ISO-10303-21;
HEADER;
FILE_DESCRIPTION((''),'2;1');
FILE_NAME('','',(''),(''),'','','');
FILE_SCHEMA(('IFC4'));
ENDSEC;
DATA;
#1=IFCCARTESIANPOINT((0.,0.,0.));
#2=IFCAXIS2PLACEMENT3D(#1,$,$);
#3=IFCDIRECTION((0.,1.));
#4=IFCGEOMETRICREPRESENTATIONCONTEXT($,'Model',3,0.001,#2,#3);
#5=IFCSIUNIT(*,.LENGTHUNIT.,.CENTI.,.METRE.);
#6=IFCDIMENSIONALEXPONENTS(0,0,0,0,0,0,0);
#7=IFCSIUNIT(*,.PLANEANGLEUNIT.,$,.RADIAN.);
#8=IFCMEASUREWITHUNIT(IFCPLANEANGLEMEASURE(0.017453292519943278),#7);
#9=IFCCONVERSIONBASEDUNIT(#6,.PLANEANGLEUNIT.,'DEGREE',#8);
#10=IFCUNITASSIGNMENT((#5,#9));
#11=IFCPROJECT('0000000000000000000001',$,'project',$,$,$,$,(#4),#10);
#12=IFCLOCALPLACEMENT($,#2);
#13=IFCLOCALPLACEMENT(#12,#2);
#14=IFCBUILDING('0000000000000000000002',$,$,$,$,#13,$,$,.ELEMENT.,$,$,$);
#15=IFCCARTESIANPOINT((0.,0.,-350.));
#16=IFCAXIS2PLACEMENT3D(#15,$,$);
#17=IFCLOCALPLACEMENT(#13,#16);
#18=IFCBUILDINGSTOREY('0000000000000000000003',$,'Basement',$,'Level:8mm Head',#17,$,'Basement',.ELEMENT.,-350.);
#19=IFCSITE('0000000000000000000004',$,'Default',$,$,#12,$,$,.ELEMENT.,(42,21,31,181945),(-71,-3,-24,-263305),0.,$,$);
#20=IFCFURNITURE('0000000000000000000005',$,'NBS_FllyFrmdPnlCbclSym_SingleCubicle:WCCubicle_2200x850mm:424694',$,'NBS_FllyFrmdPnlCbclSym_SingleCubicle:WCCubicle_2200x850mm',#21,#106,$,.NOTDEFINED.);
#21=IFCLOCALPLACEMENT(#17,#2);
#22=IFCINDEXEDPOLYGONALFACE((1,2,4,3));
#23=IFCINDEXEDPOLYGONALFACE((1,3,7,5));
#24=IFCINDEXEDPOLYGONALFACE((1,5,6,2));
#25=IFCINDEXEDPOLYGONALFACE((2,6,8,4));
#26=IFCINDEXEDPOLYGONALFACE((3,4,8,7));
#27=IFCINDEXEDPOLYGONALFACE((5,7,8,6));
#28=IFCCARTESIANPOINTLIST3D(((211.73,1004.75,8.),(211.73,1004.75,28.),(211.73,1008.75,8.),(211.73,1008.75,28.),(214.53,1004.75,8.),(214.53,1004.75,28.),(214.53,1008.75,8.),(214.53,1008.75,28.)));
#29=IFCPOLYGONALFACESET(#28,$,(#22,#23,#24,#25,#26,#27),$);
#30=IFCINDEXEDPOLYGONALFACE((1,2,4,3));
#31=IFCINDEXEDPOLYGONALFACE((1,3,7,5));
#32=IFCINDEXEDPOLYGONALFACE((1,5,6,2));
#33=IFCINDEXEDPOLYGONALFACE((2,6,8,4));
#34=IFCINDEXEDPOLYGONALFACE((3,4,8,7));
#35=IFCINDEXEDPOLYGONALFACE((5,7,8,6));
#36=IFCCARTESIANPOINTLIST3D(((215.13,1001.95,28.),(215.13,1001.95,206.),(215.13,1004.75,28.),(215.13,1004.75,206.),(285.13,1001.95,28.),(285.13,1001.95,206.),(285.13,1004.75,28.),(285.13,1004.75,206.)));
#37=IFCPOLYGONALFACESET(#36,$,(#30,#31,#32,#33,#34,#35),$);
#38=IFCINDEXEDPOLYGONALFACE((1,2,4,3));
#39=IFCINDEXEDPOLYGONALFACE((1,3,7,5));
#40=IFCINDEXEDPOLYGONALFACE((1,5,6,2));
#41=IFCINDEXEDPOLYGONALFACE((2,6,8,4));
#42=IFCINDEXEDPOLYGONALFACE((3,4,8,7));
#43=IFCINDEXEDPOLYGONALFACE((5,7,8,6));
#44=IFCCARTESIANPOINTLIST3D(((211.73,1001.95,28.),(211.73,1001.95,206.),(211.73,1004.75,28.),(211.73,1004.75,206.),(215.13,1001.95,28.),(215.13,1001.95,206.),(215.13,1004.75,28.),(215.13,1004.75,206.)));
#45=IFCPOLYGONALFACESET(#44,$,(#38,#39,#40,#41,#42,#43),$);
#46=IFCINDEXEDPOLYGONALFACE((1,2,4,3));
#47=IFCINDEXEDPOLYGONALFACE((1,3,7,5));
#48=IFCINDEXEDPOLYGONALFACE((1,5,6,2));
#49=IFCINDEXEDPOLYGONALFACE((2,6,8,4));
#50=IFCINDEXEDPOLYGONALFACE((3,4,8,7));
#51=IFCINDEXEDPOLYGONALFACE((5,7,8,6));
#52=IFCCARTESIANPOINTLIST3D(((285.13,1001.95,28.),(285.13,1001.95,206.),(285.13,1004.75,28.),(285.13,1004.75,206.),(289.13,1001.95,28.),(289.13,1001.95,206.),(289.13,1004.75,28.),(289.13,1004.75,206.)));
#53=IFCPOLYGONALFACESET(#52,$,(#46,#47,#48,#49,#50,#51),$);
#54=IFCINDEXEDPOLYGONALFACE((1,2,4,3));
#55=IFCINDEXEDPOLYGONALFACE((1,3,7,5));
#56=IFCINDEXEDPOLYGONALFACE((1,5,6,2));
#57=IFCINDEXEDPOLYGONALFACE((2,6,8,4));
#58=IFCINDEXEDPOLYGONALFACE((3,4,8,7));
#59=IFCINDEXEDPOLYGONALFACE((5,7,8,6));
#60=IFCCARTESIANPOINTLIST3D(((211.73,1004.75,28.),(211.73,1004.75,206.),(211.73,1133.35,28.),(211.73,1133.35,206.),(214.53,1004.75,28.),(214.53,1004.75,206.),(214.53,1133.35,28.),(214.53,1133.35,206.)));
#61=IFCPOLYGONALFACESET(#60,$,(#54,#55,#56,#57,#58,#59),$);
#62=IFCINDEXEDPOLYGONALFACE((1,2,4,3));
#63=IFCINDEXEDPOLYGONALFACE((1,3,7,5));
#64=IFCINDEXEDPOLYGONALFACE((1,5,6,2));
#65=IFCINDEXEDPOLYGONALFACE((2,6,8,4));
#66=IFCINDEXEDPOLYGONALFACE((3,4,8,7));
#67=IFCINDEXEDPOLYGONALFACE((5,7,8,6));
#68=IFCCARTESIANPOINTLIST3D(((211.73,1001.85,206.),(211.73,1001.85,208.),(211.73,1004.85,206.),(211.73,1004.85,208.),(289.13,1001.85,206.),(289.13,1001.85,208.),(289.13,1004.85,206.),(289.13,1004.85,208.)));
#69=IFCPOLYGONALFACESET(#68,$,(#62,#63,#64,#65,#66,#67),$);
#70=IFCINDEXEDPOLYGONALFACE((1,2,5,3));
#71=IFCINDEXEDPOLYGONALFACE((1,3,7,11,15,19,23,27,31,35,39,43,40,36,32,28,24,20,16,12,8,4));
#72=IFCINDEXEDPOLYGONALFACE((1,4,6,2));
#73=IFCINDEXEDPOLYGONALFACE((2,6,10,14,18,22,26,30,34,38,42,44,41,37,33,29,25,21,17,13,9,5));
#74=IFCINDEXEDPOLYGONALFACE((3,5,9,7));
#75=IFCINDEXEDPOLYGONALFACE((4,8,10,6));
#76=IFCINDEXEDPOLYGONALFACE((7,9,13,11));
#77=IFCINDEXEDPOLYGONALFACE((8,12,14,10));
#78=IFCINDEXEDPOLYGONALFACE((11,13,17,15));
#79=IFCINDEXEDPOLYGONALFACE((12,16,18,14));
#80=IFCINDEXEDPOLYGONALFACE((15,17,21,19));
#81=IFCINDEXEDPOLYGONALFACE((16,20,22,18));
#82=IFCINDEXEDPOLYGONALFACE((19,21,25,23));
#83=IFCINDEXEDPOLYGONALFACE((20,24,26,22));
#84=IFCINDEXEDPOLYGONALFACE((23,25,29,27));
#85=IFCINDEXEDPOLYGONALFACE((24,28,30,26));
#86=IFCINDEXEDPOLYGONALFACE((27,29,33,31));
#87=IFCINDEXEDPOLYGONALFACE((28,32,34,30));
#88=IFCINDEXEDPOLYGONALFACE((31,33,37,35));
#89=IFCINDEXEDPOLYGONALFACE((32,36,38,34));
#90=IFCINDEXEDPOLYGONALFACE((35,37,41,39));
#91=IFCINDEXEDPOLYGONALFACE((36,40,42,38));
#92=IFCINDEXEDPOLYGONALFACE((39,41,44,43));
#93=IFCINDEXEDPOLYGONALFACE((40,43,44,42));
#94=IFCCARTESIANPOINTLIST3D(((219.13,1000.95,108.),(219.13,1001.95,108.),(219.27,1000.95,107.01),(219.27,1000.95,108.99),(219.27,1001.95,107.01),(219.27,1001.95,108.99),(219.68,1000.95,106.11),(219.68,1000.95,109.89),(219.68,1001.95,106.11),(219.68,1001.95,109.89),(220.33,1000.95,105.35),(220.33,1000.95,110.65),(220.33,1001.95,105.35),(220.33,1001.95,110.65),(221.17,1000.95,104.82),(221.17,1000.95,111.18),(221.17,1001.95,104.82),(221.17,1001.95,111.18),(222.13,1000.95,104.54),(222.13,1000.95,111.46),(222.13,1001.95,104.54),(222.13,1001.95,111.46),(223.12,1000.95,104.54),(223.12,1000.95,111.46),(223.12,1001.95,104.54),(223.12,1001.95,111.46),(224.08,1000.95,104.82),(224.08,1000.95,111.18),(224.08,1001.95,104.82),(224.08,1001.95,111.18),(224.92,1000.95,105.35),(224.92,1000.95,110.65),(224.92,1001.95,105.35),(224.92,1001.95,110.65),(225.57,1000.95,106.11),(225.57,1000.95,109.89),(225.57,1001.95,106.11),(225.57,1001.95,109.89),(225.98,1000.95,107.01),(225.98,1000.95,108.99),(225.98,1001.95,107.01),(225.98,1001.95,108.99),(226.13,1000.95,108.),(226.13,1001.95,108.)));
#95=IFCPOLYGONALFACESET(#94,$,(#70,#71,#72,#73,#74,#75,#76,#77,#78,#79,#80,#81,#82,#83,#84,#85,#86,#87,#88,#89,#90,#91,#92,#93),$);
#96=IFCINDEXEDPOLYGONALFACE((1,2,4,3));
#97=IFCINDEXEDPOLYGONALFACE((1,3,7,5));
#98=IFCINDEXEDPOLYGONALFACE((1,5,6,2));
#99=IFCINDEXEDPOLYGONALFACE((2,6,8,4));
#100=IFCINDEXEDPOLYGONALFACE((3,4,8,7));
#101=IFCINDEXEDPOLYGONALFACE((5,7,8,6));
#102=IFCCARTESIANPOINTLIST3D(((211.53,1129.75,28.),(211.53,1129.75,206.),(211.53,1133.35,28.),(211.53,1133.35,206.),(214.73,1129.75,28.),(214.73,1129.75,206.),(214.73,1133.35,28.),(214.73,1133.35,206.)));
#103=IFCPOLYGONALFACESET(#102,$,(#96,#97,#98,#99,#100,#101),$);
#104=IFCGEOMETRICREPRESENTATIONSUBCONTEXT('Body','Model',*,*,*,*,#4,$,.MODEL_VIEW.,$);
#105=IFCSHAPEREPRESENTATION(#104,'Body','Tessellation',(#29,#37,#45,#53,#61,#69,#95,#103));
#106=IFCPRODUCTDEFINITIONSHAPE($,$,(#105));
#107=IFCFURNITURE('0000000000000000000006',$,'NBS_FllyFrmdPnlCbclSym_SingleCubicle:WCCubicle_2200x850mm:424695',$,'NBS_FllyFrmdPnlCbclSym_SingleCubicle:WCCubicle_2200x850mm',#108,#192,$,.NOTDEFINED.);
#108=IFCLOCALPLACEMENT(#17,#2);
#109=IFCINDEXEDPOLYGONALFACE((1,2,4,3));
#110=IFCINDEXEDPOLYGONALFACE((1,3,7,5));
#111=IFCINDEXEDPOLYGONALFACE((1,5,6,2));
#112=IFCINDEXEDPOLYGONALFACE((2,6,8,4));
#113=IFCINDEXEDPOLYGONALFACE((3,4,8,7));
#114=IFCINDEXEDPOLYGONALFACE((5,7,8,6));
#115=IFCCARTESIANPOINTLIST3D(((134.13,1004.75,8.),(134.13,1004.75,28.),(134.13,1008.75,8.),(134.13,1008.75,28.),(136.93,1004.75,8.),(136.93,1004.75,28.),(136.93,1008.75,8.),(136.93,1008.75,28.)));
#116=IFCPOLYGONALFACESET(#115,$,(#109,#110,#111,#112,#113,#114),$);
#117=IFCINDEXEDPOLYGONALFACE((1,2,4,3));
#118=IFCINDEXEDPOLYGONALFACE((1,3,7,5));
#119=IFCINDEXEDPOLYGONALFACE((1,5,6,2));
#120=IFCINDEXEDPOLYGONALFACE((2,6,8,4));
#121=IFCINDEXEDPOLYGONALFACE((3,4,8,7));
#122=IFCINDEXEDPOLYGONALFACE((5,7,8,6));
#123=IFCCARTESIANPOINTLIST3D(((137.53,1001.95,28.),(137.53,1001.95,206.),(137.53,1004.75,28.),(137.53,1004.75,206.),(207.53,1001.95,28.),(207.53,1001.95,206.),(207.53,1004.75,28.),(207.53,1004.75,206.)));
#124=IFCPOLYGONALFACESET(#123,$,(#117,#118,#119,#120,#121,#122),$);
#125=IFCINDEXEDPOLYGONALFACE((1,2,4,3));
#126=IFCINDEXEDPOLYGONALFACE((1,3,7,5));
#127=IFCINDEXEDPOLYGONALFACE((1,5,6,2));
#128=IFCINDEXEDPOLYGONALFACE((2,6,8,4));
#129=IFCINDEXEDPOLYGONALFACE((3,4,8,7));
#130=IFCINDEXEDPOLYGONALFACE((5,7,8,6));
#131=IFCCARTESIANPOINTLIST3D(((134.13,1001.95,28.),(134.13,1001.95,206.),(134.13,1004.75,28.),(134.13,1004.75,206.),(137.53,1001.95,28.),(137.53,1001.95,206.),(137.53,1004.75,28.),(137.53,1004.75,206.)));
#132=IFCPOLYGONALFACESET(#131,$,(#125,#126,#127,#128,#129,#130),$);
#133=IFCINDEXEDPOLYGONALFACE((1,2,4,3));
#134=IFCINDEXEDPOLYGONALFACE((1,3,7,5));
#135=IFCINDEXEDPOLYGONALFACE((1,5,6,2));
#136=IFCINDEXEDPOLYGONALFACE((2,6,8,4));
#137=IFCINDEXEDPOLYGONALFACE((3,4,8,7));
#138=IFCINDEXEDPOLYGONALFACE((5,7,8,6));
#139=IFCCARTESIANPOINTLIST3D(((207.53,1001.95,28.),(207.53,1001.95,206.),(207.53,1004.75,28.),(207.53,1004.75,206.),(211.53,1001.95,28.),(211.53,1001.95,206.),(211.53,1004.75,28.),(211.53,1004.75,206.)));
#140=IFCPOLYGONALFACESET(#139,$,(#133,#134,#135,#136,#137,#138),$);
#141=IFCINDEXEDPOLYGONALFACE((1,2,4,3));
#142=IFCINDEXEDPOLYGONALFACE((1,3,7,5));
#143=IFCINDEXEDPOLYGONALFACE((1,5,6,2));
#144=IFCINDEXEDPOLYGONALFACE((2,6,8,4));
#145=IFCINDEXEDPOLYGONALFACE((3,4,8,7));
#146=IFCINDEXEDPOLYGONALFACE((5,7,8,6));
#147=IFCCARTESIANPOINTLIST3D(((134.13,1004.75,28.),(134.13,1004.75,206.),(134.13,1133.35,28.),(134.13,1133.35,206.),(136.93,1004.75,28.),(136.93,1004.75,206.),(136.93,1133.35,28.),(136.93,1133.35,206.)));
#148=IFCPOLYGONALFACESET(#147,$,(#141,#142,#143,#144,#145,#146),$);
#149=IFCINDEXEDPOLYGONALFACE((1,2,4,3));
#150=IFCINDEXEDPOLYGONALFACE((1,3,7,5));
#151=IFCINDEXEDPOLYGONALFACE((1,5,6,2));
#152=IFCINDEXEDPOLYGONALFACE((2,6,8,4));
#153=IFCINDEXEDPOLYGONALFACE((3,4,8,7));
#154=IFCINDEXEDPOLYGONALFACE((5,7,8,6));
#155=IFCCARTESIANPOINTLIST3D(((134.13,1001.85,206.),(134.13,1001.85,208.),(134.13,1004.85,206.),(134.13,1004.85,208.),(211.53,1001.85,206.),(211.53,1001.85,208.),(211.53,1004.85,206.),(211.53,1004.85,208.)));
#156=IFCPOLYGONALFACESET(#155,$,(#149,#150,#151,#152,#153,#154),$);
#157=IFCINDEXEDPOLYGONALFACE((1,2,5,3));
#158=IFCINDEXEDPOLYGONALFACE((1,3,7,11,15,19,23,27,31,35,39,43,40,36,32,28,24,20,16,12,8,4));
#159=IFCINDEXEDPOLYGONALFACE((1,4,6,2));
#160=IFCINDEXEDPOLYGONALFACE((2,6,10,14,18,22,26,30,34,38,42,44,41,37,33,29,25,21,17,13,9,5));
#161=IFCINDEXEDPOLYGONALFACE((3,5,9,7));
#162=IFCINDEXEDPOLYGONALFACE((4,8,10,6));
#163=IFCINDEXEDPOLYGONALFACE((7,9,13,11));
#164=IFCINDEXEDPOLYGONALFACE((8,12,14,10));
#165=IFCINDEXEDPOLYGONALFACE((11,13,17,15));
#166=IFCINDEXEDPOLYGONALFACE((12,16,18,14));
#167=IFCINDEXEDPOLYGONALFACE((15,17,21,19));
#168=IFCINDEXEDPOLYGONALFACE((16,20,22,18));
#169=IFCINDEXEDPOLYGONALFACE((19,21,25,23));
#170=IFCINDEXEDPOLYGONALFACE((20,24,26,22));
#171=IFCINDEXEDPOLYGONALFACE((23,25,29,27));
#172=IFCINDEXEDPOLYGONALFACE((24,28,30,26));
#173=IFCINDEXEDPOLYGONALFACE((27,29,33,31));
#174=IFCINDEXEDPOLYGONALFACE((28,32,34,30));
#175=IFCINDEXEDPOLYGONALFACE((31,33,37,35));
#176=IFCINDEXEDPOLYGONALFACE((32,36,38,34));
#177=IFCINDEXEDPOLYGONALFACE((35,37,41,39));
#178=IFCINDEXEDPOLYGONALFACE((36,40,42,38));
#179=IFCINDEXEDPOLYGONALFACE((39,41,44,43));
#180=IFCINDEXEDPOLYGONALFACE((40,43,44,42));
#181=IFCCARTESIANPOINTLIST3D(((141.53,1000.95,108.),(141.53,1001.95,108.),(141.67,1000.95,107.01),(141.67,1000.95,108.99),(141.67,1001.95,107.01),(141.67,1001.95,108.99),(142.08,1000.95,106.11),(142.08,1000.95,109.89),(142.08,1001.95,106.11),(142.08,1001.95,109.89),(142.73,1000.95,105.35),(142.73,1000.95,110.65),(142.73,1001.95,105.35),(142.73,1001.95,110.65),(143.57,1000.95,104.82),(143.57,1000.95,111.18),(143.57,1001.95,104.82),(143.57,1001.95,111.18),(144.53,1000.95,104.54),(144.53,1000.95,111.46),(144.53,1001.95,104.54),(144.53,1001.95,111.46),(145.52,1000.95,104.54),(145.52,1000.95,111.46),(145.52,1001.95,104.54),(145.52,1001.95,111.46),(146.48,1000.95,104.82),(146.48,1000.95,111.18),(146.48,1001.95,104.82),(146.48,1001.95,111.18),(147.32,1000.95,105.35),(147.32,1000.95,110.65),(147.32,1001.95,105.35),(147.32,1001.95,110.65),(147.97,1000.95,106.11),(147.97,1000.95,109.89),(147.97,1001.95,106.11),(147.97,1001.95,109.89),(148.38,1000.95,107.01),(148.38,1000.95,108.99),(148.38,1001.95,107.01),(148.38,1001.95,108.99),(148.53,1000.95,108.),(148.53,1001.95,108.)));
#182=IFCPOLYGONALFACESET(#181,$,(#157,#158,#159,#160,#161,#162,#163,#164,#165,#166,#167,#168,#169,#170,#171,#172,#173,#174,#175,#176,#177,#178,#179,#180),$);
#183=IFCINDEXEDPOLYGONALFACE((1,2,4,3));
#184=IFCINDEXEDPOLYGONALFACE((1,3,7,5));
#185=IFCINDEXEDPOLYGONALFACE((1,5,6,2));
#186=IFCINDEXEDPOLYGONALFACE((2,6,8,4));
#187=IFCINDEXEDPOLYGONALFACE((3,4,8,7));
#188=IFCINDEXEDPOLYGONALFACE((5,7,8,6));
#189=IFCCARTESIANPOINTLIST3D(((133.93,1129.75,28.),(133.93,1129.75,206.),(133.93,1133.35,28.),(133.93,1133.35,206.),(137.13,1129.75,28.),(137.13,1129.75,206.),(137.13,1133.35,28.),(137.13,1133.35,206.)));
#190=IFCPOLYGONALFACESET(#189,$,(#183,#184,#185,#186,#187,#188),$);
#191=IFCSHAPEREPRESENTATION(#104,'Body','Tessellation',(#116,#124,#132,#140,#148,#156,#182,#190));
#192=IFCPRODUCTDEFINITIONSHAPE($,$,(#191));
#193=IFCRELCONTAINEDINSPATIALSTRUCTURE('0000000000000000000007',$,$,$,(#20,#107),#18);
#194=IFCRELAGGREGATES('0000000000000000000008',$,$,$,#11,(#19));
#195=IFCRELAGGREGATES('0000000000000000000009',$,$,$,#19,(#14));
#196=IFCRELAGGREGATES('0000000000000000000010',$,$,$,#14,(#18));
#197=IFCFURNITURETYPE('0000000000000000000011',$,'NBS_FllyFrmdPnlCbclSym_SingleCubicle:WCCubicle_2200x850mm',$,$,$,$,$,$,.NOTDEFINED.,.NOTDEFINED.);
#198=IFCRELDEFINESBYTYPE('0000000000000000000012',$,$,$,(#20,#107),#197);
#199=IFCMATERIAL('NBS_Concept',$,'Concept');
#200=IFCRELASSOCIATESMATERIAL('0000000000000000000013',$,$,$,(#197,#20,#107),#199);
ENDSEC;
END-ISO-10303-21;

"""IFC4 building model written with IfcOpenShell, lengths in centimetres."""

from ifc_helpers import new_model, entity, si_unit, converted_unit, direction, frame, origin, place, context, subcontext, project, spatial, arc, indexed_curve, outline, extrude, source, transform, mapped, material, type_object, type_shapes, element, save


model = new_model("IFC4")

# Units and contexts
model_context = context("Model", 3, precision=0.001, world=origin(), true_north=direction((0.0, 1.0)))
body_context = subcontext(model_context, "Body", "Model", "MODEL_VIEW")
ifc_project = project(units=[si_unit("LENGTHUNIT", "METRE", prefix="CENTI"), converted_unit("PLANEANGLEUNIT", "DEGREE", entity("IfcPlaneAngleMeasure", 0.017453292519943278), si_unit("PLANEANGLEUNIT", "RADIAN"), dimensions=[0, 0, 0, 0, 0, 0, 0])], contexts=[model_context])

# Site, building, storey
site_placement = place(None, origin())
site = spatial("IfcSite", under=ifc_project, at=site_placement, Name="Default", CompositionType="ELEMENT", RefLatitude=(42, 21, 31, 181945), RefLongitude=(-71, -3, -24, -263305), RefElevation=0.0)
building_placement = place(site_placement, origin())
building = spatial("IfcBuilding", under=site, at=building_placement, CompositionType="ELEMENT")
storey_placement = place(building_placement, frame((0.0, 0.0, -350.0)))
storey = spatial("IfcBuildingStorey", under=building, at=storey_placement, Name="Basement", ObjectType="Level:8mm Head", LongName="Basement", CompositionType="ELEMENT", Elevation=-350.0)

# Furniture
ifc_material_1 = material(Name="NBS_Concept", Category="Concept")
furniture_type = type_object("IfcFurnitureType", Name="NBS_FllyFrmdPnlCbclSym_SingleCubicle:WCCubicle_2200x850mm", AssemblyPlace="NOTDEFINED", PredefinedType="NOTDEFINED", material=ifc_material_1)
shared_shape_1 = source(origin(), body_context, "Body", "SweptSolid", [
    extrude(outline(indexed_curve([(-2.0, -1.4), (2.0, -1.4), (2.0, 1.4), (-2.0, 1.4), (-2.0, -1.4)], self_intersect=False)), frame((37.0, 126.6, 0.0), z_axis=(0.0, 0.0, 1.0), x_axis=(0.0, 1.0, 0.0)), (0.0, 0.0, 1.0), 20.0),
    extrude(outline(indexed_curve([(-1.4, -35.0), (1.4, -35.0), (1.4, 35.0), (-1.4, 35.0), (-1.4, -35.0)], self_intersect=False)), frame((0.0, 130.0, 20.0), z_axis=(0.0, 0.0, 1.0), x_axis=(0.0, 1.0, 0.0)), (0.0, 0.0, 1.0), 178.0),
    extrude(outline(indexed_curve([(-1.4, -1.7), (1.4, -1.7), (1.4, 1.7), (-1.4, 1.7), (-1.4, -1.7)], self_intersect=False)), frame((36.7, 130.0, 20.0), z_axis=(0.0, 0.0, 1.0), x_axis=(0.0, 1.0, 0.0)), (0.0, 0.0, 1.0), 178.0),
    extrude(outline(indexed_curve([(-1.4, -2.0), (1.4, -2.0), (1.4, 2.0), (-1.4, 2.0), (-1.4, -2.0)], self_intersect=False)), frame((-37.0, 130.0, 20.0), z_axis=(0.0, 0.0, 1.0), x_axis=(0.0, 1.0, 0.0)), (0.0, 0.0, 1.0), 178.0),
    extrude(outline(indexed_curve([(-64.3, -1.4), (64.3, -1.4), (64.3, 1.4), (-64.3, 1.4), (-64.3, -1.4)], self_intersect=False)), frame((37.0, 64.3, 20.0), z_axis=(0.0, 0.0, 1.0), x_axis=(0.0, 1.0, 0.0)), (0.0, 0.0, 1.0), 178.0),
    extrude(outline(indexed_curve([(-1.5, -38.7), (1.5, -38.7), (1.5, 38.7), (-1.5, 38.7), (-1.5, -38.7)], self_intersect=False)), frame((-0.3, 130.0, 198.0), z_axis=(0.0, 0.0, 1.0), x_axis=(0.0, 1.0, 0.0)), (0.0, 0.0, 1.0), 2.0),
    extrude(outline(indexed_curve([(-3.5, 0.0), (0.0, -3.5), (3.5, 0.0), (0.0, 3.5)], segments=[arc(1, 2, 3), arc(3, 4, 1)], self_intersect=False)), frame((27.5, 131.4, 100.0), z_axis=(0.0, 1.0, 0.0), x_axis=(-1.0, 0.0, 0.0)), (0.0, 0.0, 1.0), 1.0),
    extrude(outline(indexed_curve([(-1.8, -1.6), (1.8, -1.6), (1.8, 1.6), (-1.8, 1.6), (-1.8, -1.6)], self_intersect=False)), frame((37.0, 1.8, 20.0), z_axis=(0.0, 0.0, 1.0), x_axis=(0.0, 1.0, 0.0)), (0.0, 0.0, 1.0), 178.0),
])
type_shapes(furniture_type, [shared_shape_1])
for number, where, z_axis, x_axis, name in (
    (1, (250.13, 1133.35, 8.0), (0.0, 0.0, 1.0), (-1.0, 0.0, 0.0), "NBS_FllyFrmdPnlCbclSym_SingleCubicle:WCCubicle_2200x850mm:424694"),
    (2, (172.53, 1133.35, 8.0), (0.0, 0.0, 1.0), (-1.0, 0.0, 0.0), "NBS_FllyFrmdPnlCbclSym_SingleCubicle:WCCubicle_2200x850mm:424695"),
):
    element("IfcFurniture", number, at=place(storey_placement, frame(where, z_axis=z_axis, x_axis=x_axis)), inside=storey, type_object=furniture_type, material=ifc_material_1, Name=name, ObjectType="NBS_FllyFrmdPnlCbclSym_SingleCubicle:WCCubicle_2200x850mm", PredefinedType="NOTDEFINED", context=body_context, shape_type="MappedRepresentation", body=[
        mapped(shared_shape_1, transform((0.0, 0.0, 0.0), scale=1.0)),
    ])

save(model, "model.ifc")
